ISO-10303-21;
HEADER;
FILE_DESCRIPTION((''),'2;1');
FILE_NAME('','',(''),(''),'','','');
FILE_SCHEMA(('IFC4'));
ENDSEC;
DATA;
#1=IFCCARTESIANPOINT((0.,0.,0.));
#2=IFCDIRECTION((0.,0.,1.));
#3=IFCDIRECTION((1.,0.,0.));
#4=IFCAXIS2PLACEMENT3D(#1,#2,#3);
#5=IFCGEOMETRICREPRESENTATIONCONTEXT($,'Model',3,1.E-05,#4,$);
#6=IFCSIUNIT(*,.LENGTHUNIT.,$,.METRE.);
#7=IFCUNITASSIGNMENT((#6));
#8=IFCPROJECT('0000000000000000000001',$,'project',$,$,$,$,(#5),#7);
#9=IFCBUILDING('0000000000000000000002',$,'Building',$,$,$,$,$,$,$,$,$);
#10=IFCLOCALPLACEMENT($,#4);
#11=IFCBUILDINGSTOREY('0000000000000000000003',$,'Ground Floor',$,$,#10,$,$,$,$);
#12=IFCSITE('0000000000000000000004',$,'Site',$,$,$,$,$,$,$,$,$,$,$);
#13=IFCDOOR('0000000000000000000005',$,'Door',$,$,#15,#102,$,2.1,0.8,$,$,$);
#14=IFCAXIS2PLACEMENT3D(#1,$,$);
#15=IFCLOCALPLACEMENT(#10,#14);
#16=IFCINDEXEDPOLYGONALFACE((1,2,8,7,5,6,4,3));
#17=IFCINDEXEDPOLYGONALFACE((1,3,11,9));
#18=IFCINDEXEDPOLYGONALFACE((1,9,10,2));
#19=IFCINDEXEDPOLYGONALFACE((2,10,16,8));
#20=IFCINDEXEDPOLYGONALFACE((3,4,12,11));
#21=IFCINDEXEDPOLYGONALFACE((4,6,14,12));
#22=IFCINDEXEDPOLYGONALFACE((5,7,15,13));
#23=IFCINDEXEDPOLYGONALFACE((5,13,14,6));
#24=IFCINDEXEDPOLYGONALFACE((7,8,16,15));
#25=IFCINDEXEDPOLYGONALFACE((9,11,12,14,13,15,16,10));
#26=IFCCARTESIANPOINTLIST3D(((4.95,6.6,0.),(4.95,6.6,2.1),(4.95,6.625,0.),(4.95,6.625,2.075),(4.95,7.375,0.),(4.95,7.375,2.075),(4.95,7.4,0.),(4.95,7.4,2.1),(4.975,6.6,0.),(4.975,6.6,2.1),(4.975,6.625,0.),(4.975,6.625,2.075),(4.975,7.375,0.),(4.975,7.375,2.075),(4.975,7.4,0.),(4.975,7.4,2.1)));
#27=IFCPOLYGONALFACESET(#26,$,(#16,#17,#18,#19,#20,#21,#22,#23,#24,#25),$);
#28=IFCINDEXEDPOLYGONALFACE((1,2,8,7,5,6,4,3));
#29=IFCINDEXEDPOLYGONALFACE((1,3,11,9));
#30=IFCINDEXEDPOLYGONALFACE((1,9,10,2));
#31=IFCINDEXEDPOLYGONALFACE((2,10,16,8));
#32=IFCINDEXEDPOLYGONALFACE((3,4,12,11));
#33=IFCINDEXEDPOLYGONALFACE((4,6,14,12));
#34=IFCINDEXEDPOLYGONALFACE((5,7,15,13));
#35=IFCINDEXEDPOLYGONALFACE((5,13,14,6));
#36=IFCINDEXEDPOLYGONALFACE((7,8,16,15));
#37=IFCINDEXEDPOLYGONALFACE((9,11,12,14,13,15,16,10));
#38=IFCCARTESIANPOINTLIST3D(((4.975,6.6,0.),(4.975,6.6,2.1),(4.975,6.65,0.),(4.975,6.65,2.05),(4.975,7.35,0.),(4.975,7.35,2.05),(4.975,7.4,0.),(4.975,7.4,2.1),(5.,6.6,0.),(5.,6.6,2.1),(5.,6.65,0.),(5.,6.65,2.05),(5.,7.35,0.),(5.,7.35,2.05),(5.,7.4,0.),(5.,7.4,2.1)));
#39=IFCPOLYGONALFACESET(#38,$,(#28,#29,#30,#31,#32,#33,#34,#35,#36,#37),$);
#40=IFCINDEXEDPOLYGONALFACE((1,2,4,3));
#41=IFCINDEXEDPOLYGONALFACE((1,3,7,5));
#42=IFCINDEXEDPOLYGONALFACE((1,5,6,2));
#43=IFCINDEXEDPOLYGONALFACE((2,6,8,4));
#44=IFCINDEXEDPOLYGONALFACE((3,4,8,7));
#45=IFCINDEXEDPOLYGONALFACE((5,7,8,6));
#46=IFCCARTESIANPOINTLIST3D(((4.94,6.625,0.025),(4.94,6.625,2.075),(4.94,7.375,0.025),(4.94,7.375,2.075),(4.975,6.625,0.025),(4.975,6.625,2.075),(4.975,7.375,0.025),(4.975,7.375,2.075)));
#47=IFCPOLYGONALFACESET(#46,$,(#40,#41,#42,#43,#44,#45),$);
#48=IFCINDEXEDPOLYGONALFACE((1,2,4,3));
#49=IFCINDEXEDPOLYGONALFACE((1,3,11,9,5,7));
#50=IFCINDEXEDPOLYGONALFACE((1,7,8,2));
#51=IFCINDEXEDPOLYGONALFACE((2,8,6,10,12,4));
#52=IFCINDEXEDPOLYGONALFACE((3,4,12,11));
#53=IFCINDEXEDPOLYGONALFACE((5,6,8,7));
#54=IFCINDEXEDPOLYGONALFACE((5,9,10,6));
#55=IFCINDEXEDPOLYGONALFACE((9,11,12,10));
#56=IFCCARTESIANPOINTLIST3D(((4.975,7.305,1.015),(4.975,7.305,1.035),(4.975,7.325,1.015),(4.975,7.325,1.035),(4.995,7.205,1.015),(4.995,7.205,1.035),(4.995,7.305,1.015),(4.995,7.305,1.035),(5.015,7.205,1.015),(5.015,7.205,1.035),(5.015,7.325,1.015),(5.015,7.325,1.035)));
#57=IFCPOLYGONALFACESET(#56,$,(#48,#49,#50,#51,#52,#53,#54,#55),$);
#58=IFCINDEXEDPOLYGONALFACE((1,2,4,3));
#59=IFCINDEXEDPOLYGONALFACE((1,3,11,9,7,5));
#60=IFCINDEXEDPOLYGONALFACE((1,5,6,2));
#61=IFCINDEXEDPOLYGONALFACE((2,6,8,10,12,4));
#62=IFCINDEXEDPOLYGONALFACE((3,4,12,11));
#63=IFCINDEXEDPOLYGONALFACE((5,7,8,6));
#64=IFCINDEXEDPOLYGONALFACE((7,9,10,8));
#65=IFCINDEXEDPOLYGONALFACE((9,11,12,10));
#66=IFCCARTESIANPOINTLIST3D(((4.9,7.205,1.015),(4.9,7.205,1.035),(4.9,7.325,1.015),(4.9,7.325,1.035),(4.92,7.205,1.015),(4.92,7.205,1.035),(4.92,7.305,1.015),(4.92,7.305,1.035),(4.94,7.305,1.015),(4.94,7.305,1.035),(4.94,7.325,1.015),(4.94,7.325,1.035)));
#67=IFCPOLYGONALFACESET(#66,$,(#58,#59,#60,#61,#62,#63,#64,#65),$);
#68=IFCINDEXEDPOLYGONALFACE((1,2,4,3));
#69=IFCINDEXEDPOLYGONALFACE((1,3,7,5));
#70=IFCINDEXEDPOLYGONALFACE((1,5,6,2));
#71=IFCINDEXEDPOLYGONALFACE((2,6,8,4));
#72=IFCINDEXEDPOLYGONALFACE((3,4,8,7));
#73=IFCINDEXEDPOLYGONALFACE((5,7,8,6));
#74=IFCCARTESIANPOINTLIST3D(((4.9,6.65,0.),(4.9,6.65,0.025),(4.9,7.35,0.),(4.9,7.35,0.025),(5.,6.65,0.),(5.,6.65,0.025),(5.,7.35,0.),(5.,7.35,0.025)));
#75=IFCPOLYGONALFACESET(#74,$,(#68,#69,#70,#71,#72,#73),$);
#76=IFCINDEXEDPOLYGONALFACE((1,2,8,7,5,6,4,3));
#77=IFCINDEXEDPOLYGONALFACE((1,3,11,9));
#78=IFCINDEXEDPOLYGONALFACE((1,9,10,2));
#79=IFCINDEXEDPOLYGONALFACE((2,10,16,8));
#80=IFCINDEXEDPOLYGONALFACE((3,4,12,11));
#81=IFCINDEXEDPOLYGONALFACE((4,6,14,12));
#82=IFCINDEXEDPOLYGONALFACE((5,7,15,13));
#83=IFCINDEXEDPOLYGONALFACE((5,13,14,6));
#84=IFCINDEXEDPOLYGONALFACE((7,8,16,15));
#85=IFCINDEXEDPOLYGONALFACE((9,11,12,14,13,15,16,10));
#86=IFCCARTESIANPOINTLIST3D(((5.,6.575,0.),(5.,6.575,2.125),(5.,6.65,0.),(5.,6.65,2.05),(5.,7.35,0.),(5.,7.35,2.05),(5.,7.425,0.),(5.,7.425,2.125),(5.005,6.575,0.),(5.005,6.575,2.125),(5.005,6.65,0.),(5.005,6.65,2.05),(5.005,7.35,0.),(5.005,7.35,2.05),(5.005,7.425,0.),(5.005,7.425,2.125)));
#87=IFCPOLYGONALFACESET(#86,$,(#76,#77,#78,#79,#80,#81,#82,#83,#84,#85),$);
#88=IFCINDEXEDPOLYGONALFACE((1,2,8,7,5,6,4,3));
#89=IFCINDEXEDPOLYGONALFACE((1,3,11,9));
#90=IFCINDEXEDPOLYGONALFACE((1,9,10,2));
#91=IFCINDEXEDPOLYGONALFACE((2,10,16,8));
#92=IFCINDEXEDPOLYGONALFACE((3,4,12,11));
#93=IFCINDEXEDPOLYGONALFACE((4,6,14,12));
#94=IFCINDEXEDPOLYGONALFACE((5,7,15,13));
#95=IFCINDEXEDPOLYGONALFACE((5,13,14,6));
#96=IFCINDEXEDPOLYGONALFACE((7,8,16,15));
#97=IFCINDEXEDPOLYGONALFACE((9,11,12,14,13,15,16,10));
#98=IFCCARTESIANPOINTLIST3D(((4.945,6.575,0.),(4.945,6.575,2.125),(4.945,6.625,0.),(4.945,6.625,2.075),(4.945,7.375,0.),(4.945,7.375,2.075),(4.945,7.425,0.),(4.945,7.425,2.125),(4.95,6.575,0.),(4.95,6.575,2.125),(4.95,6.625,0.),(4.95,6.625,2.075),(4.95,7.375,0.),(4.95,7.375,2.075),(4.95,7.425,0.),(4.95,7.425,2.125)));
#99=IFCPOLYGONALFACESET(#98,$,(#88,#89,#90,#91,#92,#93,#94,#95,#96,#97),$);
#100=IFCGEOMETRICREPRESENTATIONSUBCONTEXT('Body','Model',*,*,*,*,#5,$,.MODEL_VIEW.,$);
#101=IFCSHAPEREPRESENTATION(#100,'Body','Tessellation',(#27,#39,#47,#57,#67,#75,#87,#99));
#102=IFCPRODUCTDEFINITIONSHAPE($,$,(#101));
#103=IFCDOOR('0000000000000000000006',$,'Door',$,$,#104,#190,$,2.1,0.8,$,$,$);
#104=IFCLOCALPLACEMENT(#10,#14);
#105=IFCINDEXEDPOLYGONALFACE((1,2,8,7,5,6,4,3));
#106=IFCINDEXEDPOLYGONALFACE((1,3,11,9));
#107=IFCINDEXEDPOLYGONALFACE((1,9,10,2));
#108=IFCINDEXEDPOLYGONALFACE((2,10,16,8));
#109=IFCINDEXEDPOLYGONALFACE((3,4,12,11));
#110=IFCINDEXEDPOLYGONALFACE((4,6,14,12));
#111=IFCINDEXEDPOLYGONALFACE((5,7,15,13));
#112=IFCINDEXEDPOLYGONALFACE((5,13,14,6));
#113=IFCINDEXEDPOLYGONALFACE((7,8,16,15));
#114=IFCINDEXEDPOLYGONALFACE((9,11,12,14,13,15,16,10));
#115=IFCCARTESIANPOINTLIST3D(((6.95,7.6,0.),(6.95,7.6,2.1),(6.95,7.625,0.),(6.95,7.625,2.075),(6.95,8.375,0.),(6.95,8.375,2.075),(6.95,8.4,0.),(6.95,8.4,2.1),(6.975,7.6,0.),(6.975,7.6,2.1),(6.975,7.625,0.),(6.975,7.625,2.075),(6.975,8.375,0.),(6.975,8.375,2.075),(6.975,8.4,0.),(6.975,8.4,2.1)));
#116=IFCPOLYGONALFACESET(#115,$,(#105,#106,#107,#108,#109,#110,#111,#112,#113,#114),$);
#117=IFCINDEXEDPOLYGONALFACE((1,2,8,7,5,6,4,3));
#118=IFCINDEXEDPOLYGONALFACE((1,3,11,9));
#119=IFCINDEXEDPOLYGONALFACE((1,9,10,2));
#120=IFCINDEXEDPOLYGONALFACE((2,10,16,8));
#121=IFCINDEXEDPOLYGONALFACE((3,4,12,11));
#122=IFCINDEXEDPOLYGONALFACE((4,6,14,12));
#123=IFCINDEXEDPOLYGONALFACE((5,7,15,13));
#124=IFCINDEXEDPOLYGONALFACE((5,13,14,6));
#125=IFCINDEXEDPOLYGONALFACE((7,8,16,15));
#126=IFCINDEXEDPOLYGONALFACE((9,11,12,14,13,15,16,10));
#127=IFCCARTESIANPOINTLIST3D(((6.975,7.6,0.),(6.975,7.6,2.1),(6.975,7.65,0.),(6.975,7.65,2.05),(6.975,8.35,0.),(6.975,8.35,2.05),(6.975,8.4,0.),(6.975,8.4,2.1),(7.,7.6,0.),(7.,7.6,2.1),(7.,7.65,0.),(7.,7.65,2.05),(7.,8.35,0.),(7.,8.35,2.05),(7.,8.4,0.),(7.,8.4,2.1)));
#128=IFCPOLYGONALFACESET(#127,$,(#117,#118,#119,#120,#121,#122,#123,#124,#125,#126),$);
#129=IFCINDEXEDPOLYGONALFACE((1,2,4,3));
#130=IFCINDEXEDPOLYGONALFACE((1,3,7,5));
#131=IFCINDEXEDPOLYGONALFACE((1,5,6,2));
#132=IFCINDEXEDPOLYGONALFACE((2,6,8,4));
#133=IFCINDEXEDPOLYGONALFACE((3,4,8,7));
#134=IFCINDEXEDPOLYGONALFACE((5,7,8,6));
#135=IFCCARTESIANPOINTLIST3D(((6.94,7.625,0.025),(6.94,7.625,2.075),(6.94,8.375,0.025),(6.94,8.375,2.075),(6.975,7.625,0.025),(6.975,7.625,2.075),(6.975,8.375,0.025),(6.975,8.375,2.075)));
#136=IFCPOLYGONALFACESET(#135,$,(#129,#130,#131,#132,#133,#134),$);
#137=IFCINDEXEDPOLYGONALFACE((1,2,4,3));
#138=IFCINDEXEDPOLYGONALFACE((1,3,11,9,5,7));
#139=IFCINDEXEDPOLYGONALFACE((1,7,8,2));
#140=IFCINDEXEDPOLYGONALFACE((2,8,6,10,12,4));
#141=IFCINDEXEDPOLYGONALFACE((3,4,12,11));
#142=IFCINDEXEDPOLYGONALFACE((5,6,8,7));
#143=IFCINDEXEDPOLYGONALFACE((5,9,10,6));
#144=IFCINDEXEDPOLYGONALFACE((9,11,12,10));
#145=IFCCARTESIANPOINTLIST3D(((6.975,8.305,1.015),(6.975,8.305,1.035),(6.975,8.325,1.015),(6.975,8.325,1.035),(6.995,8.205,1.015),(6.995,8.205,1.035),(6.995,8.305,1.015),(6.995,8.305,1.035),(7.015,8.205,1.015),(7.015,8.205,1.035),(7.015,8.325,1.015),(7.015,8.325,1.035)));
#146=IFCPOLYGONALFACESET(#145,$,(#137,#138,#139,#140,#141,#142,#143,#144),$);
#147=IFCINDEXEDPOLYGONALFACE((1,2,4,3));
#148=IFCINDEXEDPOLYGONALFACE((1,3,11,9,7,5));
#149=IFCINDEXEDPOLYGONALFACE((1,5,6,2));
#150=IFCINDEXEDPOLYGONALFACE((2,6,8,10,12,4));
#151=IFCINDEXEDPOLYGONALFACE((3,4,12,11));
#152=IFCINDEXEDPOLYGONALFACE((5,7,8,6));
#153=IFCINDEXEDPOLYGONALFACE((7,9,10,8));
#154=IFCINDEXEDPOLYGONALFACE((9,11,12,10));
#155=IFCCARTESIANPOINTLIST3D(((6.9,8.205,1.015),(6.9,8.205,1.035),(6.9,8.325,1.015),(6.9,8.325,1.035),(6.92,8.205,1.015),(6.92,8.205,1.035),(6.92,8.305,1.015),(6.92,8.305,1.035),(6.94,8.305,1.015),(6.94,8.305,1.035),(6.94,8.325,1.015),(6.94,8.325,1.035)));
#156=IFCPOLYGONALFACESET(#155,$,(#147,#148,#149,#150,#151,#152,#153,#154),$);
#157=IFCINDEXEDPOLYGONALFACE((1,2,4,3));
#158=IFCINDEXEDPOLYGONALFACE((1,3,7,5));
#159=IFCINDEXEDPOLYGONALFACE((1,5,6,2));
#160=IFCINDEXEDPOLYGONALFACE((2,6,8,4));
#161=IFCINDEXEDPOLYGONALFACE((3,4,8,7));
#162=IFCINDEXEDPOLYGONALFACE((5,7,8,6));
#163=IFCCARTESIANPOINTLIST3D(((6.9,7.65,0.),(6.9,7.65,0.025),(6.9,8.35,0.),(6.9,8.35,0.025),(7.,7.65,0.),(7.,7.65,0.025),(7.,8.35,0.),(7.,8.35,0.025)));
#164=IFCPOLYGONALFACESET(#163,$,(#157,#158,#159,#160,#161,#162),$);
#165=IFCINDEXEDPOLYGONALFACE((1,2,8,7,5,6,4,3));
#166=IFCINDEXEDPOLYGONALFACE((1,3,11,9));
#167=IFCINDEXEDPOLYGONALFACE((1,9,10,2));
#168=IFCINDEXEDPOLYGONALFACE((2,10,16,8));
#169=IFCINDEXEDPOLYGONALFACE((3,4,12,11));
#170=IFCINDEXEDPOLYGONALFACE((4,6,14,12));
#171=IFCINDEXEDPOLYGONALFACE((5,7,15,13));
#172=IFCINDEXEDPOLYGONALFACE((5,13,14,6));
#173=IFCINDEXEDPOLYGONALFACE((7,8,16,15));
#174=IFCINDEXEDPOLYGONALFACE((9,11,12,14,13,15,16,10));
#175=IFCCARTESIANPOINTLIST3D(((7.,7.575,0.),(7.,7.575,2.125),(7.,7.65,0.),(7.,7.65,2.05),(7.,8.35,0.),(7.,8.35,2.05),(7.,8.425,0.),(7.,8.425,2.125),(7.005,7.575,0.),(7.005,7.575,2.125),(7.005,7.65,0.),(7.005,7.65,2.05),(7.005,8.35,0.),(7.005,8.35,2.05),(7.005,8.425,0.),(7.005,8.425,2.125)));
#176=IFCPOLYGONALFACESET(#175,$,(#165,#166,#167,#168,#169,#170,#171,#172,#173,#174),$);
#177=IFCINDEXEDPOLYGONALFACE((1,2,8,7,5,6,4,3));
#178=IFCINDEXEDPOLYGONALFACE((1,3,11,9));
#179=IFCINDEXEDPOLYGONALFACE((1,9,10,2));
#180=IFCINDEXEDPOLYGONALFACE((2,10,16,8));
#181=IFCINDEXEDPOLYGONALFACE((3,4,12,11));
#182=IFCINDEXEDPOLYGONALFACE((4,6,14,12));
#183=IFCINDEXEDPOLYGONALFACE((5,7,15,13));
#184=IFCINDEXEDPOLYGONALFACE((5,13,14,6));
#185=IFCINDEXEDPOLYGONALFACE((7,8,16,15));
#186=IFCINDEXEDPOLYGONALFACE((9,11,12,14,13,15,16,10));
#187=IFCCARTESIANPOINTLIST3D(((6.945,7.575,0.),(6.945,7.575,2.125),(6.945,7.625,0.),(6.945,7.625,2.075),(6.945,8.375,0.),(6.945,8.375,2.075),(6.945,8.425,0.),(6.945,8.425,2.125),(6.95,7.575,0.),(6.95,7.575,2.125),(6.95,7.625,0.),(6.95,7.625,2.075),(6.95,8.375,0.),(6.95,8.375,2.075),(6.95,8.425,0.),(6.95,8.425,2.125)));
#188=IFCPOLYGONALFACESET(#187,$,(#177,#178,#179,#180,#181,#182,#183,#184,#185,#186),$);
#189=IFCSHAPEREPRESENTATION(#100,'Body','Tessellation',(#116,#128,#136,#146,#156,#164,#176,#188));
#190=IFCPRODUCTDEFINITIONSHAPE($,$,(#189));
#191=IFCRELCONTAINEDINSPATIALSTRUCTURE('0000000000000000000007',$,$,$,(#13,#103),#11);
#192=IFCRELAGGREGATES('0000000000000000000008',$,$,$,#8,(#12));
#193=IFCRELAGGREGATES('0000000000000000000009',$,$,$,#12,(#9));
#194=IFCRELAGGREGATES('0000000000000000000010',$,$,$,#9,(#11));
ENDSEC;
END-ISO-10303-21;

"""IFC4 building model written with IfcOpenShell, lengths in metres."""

from ifc_helpers import new_model, si_unit, frame, origin_with_axes, place, context, subcontext, project, spatial, line, indexed_curve, outline, extrude, element, save


model = new_model("IFC4")

# Units and contexts
model_context = context("Model", 3, precision=1e-05, world=origin_with_axes())
body_context = subcontext(model_context, "Body", "Model", "MODEL_VIEW")
ifc_project = project(units=[si_unit("LENGTHUNIT", "METRE")], contexts=[model_context])

# Site, building, storey
site = spatial("IfcSite", under=ifc_project, Name="Site")
building = spatial("IfcBuilding", under=site, Name="Building")
storey_placement = place(None, origin_with_axes())
storey = spatial("IfcBuildingStorey", under=building, at=storey_placement, Name="Ground Floor")

# Doors
door_1_placement = place(storey_placement, frame((5.0, 6.6, 0.0), z_axis=(0.0, 0.0, 1.0), x_axis=(0.0, 1.0, 0.0)))
element("IfcDoor", 1, at=door_1_placement, inside=storey, Name="Door", OverallHeight=2.1, OverallWidth=0.8, context=body_context, shape_type="SweptSolid", body=[
    extrude(outline(indexed_curve([(0.0, 0.0), (0.0, 2.1), (0.8, 2.1), (0.8, 0.0), (0.775, 0.0), (0.775, 2.075), (0.025, 2.075), (0.025, 0.0)], segments=[line(1, 2, 3, 4, 5, 6, 7, 8, 1)])), frame((0.0, 0.025, 0.0), z_axis=(0.0, -1.0, 0.0), x_axis=(1.0, 0.0, 0.0)), (0.0, 0.0, -1.0), 0.025),
    extrude(outline(indexed_curve([(0.0, 0.0), (0.0, 2.1), (0.8, 2.1), (0.8, 0.0), (0.75, 0.0), (0.75, 2.05), (0.05, 2.05), (0.05, 0.0)], segments=[line(1, 2, 3, 4, 5, 6, 7, 8, 1)])), frame((0.0, 0.0, 0.0), z_axis=(0.0, -1.0, 0.0), x_axis=(1.0, 0.0, 0.0)), (0.0, 0.0, -1.0), 0.025),
    extrude(outline(indexed_curve([(0.0, 0.0), (0.75, 0.0), (0.75, 0.035), (0.0, 0.035)], segments=[line(1, 2, 3, 4, 1)])), frame((0.025, 0.025, 0.025), z_axis=(0.0, 0.0, 1.0), x_axis=(1.0, 0.0, 0.0)), (0.0, 0.0, 1.0), 2.05),
    extrude(outline(indexed_curve([(0.0, 0.0), (0.0, -0.04), (-0.12, -0.04), (-0.12, -0.02), (-0.02, -0.02), (-0.02, 0.0)], segments=[line(1, 2, 3, 4, 5, 6, 1)])), frame((0.725, 0.025, 1.015), z_axis=(0.0, 0.0, 1.0), x_axis=(1.0, 0.0, 0.0)), (0.0, 0.0, 1.0), 0.02),
    extrude(outline(indexed_curve([(0.0, 0.0), (0.0, 0.04), (-0.12, 0.04), (-0.12, 0.02), (-0.02, 0.02), (-0.02, 0.0)], segments=[line(1, 2, 3, 4, 5, 6, 1)])), frame((0.725, 0.06, 1.015), z_axis=(0.0, 0.0, 1.0), x_axis=(1.0, 0.0, 0.0)), (0.0, 0.0, 1.0), 0.02),
    extrude(outline(indexed_curve([(0.0, 0.0), (0.7, 0.0), (0.7, 0.1), (0.0, 0.1)], segments=[line(1, 2, 3, 4, 1)])), frame((0.05, 0.0, 0.0), z_axis=(0.0, 0.0, 1.0), x_axis=(1.0, 0.0, 0.0)), (0.0, 0.0, 1.0), 0.025),
    extrude(outline(indexed_curve([(0.0, 0.0), (0.0, 2.125), (0.85, 2.125), (0.85, 0.0), (0.775, 0.0), (0.775, 2.05), (0.075, 2.05), (0.075, 0.0)], segments=[line(1, 2, 3, 4, 5, 6, 7, 8, 1)])), frame((-0.025, -0.005, 0.0), z_axis=(0.0, -1.0, 0.0), x_axis=(1.0, 0.0, 0.0)), (0.0, 0.0, -1.0), 0.005),
    extrude(outline(indexed_curve([(0.0, 0.0), (0.0, 2.125), (0.85, 2.125), (0.85, 0.0), (0.8, 0.0), (0.8, 2.075), (0.05, 2.075), (0.05, 0.0)], segments=[line(1, 2, 3, 4, 5, 6, 7, 8, 1)])), frame((-0.025, 0.05, 0.0), z_axis=(0.0, -1.0, 0.0), x_axis=(1.0, 0.0, 0.0)), (0.0, 0.0, -1.0), 0.005),
])
door_2_placement = place(storey_placement, frame((7.0, 7.6, 0.0), z_axis=(0.0, 0.0, 1.0), x_axis=(0.0, 1.0, 0.0)))
element("IfcDoor", 2, at=door_2_placement, inside=storey, Name="Door", OverallHeight=2.1, OverallWidth=0.8, context=body_context, shape_type="SweptSolid", body=[
    extrude(outline(indexed_curve([(0.0, 0.0), (0.0, 2.1), (0.8, 2.1), (0.8, 0.0), (0.775, 0.0), (0.775, 2.075), (0.025, 2.075), (0.025, 0.0)], segments=[line(1, 2, 3, 4, 5, 6, 7, 8, 1)])), frame((0.0, 0.025, 0.0), z_axis=(0.0, -1.0, 0.0), x_axis=(1.0, 0.0, 0.0)), (0.0, 0.0, -1.0), 0.025),
    extrude(outline(indexed_curve([(0.0, 0.0), (0.0, 2.1), (0.8, 2.1), (0.8, 0.0), (0.75, 0.0), (0.75, 2.05), (0.05, 2.05), (0.05, 0.0)], segments=[line(1, 2, 3, 4, 5, 6, 7, 8, 1)])), frame((0.0, 0.0, 0.0), z_axis=(0.0, -1.0, 0.0), x_axis=(1.0, 0.0, 0.0)), (0.0, 0.0, -1.0), 0.025),
    extrude(outline(indexed_curve([(0.0, 0.0), (0.75, 0.0), (0.75, 0.035), (0.0, 0.035)], segments=[line(1, 2, 3, 4, 1)])), frame((0.025, 0.025, 0.025), z_axis=(0.0, 0.0, 1.0), x_axis=(1.0, 0.0, 0.0)), (0.0, 0.0, 1.0), 2.05),
    extrude(outline(indexed_curve([(0.0, 0.0), (0.0, -0.04), (-0.12, -0.04), (-0.12, -0.02), (-0.02, -0.02), (-0.02, 0.0)], segments=[line(1, 2, 3, 4, 5, 6, 1)])), frame((0.725, 0.025, 1.015), z_axis=(0.0, 0.0, 1.0), x_axis=(1.0, 0.0, 0.0)), (0.0, 0.0, 1.0), 0.02),
    extrude(outline(indexed_curve([(0.0, 0.0), (0.0, 0.04), (-0.12, 0.04), (-0.12, 0.02), (-0.02, 0.02), (-0.02, 0.0)], segments=[line(1, 2, 3, 4, 5, 6, 1)])), frame((0.725, 0.06, 1.015), z_axis=(0.0, 0.0, 1.0), x_axis=(1.0, 0.0, 0.0)), (0.0, 0.0, 1.0), 0.02),
    extrude(outline(indexed_curve([(0.0, 0.0), (0.7, 0.0), (0.7, 0.1), (0.0, 0.1)], segments=[line(1, 2, 3, 4, 1)])), frame((0.05, 0.0, 0.0), z_axis=(0.0, 0.0, 1.0), x_axis=(1.0, 0.0, 0.0)), (0.0, 0.0, 1.0), 0.025),
    extrude(outline(indexed_curve([(0.0, 0.0), (0.0, 2.125), (0.85, 2.125), (0.85, 0.0), (0.775, 0.0), (0.775, 2.05), (0.075, 2.05), (0.075, 0.0)], segments=[line(1, 2, 3, 4, 5, 6, 7, 8, 1)])), frame((-0.025, -0.005, 0.0), z_axis=(0.0, -1.0, 0.0), x_axis=(1.0, 0.0, 0.0)), (0.0, 0.0, -1.0), 0.005),
    extrude(outline(indexed_curve([(0.0, 0.0), (0.0, 2.125), (0.85, 2.125), (0.85, 0.0), (0.8, 0.0), (0.8, 2.075), (0.05, 2.075), (0.05, 0.0)], segments=[line(1, 2, 3, 4, 5, 6, 7, 8, 1)])), frame((-0.025, 0.05, 0.0), z_axis=(0.0, -1.0, 0.0), x_axis=(1.0, 0.0, 0.0)), (0.0, 0.0, -1.0), 0.005),
])

save(model, "model.ifc")
